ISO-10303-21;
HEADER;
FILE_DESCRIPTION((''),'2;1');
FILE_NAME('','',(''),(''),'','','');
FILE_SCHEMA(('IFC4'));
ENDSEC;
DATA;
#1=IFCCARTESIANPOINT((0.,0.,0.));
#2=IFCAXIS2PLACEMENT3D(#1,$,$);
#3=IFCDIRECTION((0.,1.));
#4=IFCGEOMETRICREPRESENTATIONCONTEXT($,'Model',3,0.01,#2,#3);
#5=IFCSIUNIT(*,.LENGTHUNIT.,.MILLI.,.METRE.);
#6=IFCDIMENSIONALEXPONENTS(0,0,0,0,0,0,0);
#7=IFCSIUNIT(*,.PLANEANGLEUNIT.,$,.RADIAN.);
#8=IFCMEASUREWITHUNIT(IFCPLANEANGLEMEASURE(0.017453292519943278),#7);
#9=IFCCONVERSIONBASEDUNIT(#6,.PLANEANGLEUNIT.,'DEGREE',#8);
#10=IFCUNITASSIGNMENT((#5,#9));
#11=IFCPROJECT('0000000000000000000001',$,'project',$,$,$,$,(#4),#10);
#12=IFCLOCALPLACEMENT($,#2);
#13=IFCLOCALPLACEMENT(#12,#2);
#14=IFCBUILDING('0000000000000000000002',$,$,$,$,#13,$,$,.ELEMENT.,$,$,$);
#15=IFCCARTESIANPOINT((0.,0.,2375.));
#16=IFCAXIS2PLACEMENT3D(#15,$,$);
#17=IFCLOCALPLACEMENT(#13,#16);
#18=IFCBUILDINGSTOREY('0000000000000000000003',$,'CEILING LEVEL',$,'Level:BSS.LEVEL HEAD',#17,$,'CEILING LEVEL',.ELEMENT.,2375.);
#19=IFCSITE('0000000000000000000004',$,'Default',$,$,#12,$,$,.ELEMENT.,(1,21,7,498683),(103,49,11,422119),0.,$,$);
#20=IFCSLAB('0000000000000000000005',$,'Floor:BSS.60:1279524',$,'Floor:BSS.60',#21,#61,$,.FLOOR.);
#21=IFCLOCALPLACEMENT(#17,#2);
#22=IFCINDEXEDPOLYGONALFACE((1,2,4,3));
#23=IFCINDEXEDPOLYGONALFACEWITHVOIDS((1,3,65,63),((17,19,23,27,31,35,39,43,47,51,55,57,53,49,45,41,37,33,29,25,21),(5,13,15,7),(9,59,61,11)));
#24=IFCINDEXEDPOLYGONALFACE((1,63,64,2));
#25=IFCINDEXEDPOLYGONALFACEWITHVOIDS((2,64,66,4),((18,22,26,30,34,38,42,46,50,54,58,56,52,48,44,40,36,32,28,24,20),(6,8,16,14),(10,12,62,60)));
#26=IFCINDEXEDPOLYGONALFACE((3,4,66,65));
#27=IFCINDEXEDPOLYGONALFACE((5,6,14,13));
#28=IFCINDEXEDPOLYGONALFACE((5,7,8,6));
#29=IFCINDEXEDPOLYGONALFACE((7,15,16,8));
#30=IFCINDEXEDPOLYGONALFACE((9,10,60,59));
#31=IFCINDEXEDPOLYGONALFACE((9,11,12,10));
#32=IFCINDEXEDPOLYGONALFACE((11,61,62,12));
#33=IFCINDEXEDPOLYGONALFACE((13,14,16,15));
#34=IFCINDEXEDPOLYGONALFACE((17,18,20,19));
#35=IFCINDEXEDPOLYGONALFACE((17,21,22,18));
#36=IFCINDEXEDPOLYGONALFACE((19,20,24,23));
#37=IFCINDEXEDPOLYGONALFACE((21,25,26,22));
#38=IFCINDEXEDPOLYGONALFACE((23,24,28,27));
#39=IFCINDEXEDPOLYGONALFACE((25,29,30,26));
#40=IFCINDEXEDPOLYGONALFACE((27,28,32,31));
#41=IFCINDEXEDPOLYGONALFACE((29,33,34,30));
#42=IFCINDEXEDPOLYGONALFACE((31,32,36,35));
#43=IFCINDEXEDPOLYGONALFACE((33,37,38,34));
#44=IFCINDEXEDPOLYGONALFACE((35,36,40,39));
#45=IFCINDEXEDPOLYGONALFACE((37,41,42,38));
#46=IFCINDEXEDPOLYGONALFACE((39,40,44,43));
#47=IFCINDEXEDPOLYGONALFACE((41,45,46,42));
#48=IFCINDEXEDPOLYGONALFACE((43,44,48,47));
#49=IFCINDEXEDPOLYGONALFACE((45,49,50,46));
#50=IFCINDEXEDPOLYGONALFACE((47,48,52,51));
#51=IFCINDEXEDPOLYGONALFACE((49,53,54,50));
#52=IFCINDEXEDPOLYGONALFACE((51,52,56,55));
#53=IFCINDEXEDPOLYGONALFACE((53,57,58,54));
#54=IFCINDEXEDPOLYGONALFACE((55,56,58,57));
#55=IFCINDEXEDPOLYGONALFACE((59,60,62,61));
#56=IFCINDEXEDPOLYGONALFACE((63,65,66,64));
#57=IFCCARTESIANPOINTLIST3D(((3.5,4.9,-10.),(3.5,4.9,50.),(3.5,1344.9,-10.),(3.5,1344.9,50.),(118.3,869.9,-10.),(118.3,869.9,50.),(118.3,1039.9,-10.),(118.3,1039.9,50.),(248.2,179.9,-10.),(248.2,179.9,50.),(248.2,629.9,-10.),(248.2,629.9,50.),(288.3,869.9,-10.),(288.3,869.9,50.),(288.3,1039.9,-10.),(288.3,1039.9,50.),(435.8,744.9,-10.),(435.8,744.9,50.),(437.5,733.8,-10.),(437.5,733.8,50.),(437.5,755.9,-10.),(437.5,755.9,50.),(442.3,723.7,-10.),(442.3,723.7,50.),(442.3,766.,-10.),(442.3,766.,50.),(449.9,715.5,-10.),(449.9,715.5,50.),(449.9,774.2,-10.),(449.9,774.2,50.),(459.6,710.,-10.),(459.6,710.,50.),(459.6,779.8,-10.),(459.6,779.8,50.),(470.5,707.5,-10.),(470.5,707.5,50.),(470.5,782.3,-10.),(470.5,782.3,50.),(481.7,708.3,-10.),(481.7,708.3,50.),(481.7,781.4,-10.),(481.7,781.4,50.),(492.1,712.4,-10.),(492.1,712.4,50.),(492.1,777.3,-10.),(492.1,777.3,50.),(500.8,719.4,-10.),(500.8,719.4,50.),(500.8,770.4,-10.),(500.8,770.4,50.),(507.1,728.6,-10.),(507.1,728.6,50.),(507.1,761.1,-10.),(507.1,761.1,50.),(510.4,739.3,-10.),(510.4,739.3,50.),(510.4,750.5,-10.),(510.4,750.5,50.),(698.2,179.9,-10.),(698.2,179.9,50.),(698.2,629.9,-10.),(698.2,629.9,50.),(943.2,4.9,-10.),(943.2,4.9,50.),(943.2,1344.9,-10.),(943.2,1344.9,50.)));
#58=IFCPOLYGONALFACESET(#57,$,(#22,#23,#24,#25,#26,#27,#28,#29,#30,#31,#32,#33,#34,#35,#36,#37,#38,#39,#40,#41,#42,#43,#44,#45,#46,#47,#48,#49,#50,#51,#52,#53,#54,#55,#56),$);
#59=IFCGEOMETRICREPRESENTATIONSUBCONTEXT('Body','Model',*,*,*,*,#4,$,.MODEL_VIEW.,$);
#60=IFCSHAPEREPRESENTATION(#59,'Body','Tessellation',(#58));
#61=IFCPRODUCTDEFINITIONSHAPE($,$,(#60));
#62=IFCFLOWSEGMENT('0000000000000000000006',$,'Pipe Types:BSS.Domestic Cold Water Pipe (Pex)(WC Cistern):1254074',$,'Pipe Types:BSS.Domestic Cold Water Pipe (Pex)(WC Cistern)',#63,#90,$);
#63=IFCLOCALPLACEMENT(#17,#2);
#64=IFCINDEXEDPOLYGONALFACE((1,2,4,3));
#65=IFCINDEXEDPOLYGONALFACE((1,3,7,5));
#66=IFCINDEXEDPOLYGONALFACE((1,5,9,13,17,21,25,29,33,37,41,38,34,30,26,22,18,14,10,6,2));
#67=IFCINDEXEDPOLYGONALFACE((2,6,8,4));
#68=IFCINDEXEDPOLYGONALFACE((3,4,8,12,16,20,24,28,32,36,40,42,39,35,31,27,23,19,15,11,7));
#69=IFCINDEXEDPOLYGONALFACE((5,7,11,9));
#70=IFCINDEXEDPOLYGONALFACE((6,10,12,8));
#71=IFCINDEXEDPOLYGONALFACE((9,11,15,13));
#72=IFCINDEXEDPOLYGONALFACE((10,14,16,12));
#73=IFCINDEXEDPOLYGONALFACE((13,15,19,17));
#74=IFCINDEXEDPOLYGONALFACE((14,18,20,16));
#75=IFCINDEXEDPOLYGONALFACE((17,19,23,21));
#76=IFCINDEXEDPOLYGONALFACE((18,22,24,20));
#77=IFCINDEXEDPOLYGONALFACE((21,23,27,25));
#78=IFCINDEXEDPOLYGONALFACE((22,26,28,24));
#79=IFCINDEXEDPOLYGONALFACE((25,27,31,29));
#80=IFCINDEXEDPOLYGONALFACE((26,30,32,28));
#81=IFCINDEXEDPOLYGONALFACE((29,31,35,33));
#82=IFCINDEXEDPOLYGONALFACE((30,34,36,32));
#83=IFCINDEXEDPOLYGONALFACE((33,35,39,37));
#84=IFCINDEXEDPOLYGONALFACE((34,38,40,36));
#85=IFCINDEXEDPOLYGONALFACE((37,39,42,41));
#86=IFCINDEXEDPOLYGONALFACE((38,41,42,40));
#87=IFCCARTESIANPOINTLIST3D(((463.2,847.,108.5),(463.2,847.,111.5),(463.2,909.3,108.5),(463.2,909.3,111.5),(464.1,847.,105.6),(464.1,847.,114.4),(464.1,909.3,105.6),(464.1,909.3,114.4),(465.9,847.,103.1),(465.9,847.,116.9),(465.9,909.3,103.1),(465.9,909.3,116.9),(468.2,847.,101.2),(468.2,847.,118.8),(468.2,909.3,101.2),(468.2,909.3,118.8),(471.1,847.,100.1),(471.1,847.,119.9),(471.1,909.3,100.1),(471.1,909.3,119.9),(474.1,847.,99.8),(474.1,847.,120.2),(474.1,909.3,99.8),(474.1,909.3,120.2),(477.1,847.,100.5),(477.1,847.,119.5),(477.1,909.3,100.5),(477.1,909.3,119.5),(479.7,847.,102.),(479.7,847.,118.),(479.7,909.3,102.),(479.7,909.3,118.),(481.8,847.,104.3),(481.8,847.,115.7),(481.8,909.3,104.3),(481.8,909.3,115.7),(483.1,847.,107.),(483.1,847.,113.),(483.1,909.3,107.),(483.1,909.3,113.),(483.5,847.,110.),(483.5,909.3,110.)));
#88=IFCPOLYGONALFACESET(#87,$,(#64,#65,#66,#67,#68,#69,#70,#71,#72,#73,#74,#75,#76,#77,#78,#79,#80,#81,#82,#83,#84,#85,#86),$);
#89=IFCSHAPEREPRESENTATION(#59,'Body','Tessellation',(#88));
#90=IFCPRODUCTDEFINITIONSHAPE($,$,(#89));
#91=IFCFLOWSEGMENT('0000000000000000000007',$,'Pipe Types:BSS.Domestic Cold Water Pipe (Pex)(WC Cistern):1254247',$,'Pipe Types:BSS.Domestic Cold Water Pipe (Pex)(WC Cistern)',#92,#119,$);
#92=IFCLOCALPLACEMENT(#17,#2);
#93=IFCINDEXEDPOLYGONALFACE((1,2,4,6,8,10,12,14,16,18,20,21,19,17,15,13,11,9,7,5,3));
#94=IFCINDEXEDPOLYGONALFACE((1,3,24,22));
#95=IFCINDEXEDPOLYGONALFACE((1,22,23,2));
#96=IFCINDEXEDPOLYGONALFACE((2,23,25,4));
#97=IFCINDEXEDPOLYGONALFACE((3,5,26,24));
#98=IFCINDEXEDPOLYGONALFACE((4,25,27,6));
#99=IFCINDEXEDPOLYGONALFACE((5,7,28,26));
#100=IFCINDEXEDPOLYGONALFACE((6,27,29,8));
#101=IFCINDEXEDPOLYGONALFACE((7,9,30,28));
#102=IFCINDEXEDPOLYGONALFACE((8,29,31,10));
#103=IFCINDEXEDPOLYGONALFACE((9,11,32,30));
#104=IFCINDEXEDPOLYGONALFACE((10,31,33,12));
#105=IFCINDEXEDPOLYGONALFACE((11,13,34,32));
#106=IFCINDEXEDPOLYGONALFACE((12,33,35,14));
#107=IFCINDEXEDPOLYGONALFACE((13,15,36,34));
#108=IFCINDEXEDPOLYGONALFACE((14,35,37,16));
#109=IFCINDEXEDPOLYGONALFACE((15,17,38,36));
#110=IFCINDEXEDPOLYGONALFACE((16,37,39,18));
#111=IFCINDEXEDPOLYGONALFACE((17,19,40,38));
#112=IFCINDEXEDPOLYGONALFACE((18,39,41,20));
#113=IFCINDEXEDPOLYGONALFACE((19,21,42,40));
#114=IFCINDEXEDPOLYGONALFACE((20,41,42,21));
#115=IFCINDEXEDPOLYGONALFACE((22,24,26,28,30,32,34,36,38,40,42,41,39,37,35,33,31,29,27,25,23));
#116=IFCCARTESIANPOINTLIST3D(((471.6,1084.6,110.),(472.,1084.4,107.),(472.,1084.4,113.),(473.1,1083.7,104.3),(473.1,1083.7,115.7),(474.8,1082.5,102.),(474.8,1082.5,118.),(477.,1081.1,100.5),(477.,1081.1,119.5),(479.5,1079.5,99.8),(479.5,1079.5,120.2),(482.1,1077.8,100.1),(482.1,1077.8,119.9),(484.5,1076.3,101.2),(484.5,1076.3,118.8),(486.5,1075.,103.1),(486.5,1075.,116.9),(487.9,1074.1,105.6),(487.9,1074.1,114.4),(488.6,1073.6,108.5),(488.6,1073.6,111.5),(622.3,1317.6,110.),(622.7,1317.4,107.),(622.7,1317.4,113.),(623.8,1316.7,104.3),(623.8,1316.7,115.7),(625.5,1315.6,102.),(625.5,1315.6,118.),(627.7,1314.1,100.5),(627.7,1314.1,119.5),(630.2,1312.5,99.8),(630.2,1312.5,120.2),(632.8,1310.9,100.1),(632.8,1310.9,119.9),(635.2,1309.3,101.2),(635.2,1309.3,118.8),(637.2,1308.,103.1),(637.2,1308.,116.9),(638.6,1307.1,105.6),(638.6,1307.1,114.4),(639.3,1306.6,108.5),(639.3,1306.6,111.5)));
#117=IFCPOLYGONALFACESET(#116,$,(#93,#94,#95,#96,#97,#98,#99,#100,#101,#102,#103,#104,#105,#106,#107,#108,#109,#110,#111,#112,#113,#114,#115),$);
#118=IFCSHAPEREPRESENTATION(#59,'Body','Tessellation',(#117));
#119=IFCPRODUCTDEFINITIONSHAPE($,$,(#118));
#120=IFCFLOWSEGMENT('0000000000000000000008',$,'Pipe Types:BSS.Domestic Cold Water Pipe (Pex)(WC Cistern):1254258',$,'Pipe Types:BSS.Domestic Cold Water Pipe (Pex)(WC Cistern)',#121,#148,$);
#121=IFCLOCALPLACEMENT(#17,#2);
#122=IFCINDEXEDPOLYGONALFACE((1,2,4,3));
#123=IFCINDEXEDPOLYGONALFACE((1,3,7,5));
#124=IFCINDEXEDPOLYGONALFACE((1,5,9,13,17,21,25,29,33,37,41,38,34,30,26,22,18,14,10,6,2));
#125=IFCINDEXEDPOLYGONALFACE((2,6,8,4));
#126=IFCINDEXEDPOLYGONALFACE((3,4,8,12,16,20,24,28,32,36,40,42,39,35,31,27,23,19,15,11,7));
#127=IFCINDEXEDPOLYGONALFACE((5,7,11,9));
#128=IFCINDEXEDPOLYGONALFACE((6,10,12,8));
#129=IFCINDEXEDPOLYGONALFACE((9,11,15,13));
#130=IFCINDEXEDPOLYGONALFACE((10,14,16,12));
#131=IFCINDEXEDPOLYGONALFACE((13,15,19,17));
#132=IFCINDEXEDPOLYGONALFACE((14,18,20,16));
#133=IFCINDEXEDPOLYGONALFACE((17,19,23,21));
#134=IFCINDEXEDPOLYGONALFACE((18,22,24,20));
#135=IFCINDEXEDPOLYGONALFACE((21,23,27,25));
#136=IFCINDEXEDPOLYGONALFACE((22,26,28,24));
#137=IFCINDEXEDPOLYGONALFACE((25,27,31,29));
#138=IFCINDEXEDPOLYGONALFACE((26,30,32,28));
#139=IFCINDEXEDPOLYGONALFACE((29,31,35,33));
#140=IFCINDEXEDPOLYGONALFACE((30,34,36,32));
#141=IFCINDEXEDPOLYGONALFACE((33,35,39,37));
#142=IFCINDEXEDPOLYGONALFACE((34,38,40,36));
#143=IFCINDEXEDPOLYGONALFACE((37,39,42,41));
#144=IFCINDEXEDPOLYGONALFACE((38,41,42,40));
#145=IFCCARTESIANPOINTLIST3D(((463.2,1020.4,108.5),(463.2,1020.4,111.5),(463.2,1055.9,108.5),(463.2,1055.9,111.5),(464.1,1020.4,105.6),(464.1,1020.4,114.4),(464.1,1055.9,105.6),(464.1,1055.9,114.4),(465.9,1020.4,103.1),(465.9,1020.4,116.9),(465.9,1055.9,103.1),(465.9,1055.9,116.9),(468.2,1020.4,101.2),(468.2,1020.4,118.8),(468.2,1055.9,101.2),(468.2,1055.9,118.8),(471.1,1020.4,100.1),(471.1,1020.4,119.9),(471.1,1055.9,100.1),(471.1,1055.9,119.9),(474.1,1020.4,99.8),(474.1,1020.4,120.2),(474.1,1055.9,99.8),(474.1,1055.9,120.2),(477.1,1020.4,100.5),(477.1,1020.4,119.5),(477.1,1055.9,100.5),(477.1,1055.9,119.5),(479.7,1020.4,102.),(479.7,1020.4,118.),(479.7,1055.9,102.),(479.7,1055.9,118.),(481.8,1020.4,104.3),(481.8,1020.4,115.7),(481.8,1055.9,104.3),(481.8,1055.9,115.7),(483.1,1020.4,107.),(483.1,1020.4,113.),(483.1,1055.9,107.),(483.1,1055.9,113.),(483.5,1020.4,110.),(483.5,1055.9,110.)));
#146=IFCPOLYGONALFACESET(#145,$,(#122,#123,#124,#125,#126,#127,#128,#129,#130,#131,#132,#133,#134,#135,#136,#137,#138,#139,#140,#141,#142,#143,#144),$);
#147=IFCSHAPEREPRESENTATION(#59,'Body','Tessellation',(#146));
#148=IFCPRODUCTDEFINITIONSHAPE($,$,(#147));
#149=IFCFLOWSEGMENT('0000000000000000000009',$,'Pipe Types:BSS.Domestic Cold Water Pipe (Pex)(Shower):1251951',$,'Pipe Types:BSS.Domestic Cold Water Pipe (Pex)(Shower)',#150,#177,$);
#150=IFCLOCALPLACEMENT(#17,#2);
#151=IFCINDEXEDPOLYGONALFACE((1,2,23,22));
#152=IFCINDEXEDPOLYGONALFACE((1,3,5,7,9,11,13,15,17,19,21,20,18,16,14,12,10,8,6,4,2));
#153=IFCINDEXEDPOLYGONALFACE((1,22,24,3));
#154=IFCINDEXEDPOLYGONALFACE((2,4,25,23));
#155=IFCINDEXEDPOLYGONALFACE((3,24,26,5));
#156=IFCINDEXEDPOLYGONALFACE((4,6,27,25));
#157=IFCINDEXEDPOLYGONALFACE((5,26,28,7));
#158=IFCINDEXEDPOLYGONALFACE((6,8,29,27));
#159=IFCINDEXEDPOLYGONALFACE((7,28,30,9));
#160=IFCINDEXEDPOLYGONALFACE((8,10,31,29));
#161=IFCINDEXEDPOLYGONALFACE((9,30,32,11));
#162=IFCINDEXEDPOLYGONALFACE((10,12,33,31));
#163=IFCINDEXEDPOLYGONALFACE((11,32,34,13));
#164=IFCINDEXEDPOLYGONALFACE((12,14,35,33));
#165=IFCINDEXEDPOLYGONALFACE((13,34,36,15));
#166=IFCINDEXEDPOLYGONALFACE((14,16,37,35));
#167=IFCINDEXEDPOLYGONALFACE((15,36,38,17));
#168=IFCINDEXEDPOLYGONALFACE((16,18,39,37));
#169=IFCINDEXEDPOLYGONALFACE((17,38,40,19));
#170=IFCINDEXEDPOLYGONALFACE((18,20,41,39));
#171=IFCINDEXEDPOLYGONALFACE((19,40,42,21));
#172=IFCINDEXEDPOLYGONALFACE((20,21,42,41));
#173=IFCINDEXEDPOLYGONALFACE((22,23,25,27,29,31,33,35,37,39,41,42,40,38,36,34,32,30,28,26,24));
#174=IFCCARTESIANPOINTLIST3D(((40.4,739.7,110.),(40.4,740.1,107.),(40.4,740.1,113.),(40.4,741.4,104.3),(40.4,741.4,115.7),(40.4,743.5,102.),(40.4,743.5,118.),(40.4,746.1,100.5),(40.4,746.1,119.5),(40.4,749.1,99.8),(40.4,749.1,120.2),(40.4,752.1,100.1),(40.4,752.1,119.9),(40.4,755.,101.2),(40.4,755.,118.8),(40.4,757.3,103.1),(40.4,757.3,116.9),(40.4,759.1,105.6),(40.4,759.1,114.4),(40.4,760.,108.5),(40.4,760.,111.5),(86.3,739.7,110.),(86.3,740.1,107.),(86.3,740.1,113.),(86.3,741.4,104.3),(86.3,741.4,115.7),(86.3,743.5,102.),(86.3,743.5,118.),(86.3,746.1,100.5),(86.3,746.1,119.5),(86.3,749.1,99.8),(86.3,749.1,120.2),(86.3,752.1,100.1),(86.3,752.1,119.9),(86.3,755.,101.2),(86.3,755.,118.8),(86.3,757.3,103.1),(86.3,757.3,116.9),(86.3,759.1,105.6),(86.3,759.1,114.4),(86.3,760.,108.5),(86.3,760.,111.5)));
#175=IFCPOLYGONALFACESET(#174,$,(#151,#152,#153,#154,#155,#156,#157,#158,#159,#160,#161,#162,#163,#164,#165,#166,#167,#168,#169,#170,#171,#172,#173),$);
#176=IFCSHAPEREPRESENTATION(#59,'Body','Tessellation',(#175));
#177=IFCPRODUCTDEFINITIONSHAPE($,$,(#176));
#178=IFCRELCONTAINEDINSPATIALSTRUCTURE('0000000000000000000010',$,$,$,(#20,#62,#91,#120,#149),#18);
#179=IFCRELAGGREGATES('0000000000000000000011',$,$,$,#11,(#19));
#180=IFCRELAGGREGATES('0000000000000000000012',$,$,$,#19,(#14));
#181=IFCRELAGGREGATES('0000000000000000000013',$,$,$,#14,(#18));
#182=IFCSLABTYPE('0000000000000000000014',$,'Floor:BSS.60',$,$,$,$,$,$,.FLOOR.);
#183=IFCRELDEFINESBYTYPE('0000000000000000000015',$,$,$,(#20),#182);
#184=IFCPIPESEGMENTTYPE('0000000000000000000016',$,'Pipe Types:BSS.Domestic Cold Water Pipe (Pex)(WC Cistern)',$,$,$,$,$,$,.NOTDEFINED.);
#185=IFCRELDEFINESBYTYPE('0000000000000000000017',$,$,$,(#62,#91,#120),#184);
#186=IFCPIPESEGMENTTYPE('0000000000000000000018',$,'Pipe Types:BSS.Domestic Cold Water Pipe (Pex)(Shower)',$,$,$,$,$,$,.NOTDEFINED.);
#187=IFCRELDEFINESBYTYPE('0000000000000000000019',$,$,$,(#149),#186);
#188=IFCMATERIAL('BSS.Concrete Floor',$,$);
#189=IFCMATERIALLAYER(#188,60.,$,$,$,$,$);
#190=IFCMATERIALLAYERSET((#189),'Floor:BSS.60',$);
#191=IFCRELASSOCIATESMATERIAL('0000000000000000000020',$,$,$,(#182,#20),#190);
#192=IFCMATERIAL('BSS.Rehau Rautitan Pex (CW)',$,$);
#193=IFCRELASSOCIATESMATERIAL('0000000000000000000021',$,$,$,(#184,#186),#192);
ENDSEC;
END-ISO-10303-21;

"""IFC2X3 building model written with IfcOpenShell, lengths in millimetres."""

from ifc_helpers import new_model, entity, si_unit, converted_unit, direction, frame, frame_2d, origin, origin_2d_with_axis, place, context, subcontext, project, spatial, rectangle, circle, extrude, material, layer, layer_set, layer_usage, type_object, element, save


model = new_model("IFC2X3")

# Units and contexts
model_context = context("Model", 3, precision=0.01, world=origin(), true_north=direction((0.0, 1.0)))
body_context = subcontext(model_context, "Body", "Model", "MODEL_VIEW")
ifc_project = project(units=[si_unit("LENGTHUNIT", "METRE", prefix="MILLI"), converted_unit("PLANEANGLEUNIT", "DEGREE", entity("IfcPlaneAngleMeasure", 0.017453292519943278), si_unit("PLANEANGLEUNIT", "RADIAN"), dimensions=[0, 0, 0, 0, 0, 0, 0])], contexts=[model_context])

# Site, building, storey
site_placement = place(None, origin())
site = spatial("IfcSite", under=ifc_project, at=site_placement, Name="Default", CompositionType="ELEMENT", RefLatitude=(1, 21, 7, 498683), RefLongitude=(103, 49, 11, 422119), RefElevation=0.0)
building_placement = place(site_placement, origin())
building = spatial("IfcBuilding", under=site, at=building_placement, CompositionType="ELEMENT")
storey_placement = place(building_placement, frame((0.0, 0.0, 2375.0)))
storey = spatial("IfcBuildingStorey", under=building, at=storey_placement, Name="CEILING LEVEL", ObjectType="Level:BSS.LEVEL HEAD", LongName="CEILING LEVEL", CompositionType="ELEMENT", Elevation=2375.0)

# Slab, openings
ifc_material_1 = material(Name="BSS.Concrete Floor")
ifc_layer = layer(ifc_material_1, 60.0)
ifc_layer_set = layer_set([ifc_layer], Name="Floor:BSS.60")
ifc_layer_usage = layer_usage(ifc_layer_set, "AXIS3", "POSITIVE", 0.0)
slab_type = type_object("IfcSlabType", Name="Floor:BSS.60", PredefinedType="FLOOR", material=ifc_layer_set)
slab_placement = place(storey_placement, frame((3.5, 4.9, -10.0)))
slab = element("IfcSlab", 1, at=slab_placement, inside=storey, type_object=slab_type, material=ifc_layer_usage, Name="Floor:BSS.60:1279524", ObjectType="Floor:BSS.60", PredefinedType="FLOOR", context=body_context, shape_type="SweptSolid", body=[
    extrude(rectangle(XDim=1340.0, YDim=939.7, at=frame_2d((0.0, 0.0), x_axis=(0.0, -1.0))), frame((469.9, 670.0, 60.0), z_axis=(0.0, 0.0, -1.0), x_axis=(-1.0, 0.0, 0.0)), (0.0, 0.0, 1.0), 60.0),
])
opening_1_placement = place(slab_placement, origin())
element("IfcOpeningElement", 2, at=opening_1_placement, cuts=slab, ObjectType="Opening", context=body_context, shape_type="SweptSolid", body=[
    extrude(circle(Radius=37.5, at=frame_2d((0.0, 70.0), x_axis=(1.0, 0.0))), frame((469.9, 670.0, 60.0), z_axis=(0.0, 0.0, -1.0), x_axis=(-1.0, 0.0, 0.0)), (0.0, 0.0, 1.0), 60.0),
])
opening_2_placement = place(slab_placement, origin())
element("IfcOpeningElement", 3, at=opening_2_placement, cuts=slab, ObjectType="Opening", context=body_context, shape_type="SweptSolid", body=[
    extrude(rectangle(XDim=170.0, YDim=170.0, at=frame_2d((270.0, 280.0), x_axis=(0.0, -1.0))), frame((469.9, 670.0, 60.0), z_axis=(0.0, 0.0, -1.0), x_axis=(-1.0, 0.0, 0.0)), (0.0, 0.0, 1.0), 60.0),
])
opening_3_placement = place(slab_placement, origin())
element("IfcOpeningElement", 4, at=opening_3_placement, cuts=slab, ObjectType="Opening", context=body_context, shape_type="SweptSolid", body=[
    extrude(rectangle(XDim=450.0, YDim=450.0, at=frame_2d((0.1, -270.0), x_axis=(0.0, -1.0))), frame((469.9, 670.0, 60.0), z_axis=(0.0, 0.0, -1.0), x_axis=(-1.0, 0.0, 0.0)), (0.0, 0.0, 1.0), 60.0),
])

# Flow segments
ifc_material_2 = material(Name="BSS.Rehau Rautitan Pex (CW)")
pipe_segment_type_1 = type_object("IfcPipeSegmentType", Name="Pipe Types:BSS.Domestic Cold Water Pipe (Pex)(WC Cistern)", PredefinedType="NOTDEFINED", material=ifc_material_2)
flow_segment_1_placement = place(storey_placement, origin())
element("IfcFlowSegment", 5, at=flow_segment_1_placement, inside=storey, type_object=pipe_segment_type_1, Name="Pipe Types:BSS.Domestic Cold Water Pipe (Pex)(WC Cistern):1254074", ObjectType="Pipe Types:BSS.Domestic Cold Water Pipe (Pex)(WC Cistern)", context=body_context, shape_type="SweptSolid", body=[
    extrude(circle(Radius=10.2, at=origin_2d_with_axis()), frame((473.3, 847.0, 110.0), z_axis=(0.0, 1.0, 0.0), x_axis=(1.0, 0.0, 0.0)), (0.0, 0.0, 1.0), 62.3),
])
flow_segment_2_placement = place(storey_placement, origin())
element("IfcFlowSegment", 6, at=flow_segment_2_placement, inside=storey, type_object=pipe_segment_type_1, Name="Pipe Types:BSS.Domestic Cold Water Pipe (Pex)(WC Cistern):1254247", ObjectType="Pipe Types:BSS.Domestic Cold Water Pipe (Pex)(WC Cistern)", context=body_context, shape_type="SweptSolid", body=[
    extrude(circle(Radius=10.2, at=origin_2d_with_axis()), frame((480.2, 1079.1, 110.0), z_axis=(0.543056, 0.839696, 0.0), x_axis=(-0.839696, 0.543056, 0.0)), (0.0, 0.0, 1.0), 277.5),
])
flow_segment_3_placement = place(storey_placement, origin())
element("IfcFlowSegment", 7, at=flow_segment_3_placement, inside=storey, type_object=pipe_segment_type_1, Name="Pipe Types:BSS.Domestic Cold Water Pipe (Pex)(WC Cistern):1254258", ObjectType="Pipe Types:BSS.Domestic Cold Water Pipe (Pex)(WC Cistern)", context=body_context, shape_type="SweptSolid", body=[
    extrude(circle(Radius=10.2, at=origin_2d_with_axis()), frame((473.3, 1020.4, 110.0), z_axis=(0.0, 1.0, 0.0), x_axis=(1.0, 0.0, 0.0)), (0.0, 0.0, 1.0), 35.5),
])
pipe_segment_type_2 = type_object("IfcPipeSegmentType", Name="Pipe Types:BSS.Domestic Cold Water Pipe (Pex)(Shower)", PredefinedType="NOTDEFINED", material=ifc_material_2)
flow_segment_4_placement = place(storey_placement, origin())
element("IfcFlowSegment", 8, at=flow_segment_4_placement, inside=storey, type_object=pipe_segment_type_2, Name="Pipe Types:BSS.Domestic Cold Water Pipe (Pex)(Shower):1251951", ObjectType="Pipe Types:BSS.Domestic Cold Water Pipe (Pex)(Shower)", context=body_context, shape_type="SweptSolid", body=[
    extrude(circle(Radius=10.2, at=origin_2d_with_axis()), frame((40.4, 749.9, 110.0), z_axis=(1.0, 0.0, 0.0), x_axis=(0.0, -1.0, 0.0)), (0.0, 0.0, 1.0), 45.9),
])

save(model, "model.ifc")
